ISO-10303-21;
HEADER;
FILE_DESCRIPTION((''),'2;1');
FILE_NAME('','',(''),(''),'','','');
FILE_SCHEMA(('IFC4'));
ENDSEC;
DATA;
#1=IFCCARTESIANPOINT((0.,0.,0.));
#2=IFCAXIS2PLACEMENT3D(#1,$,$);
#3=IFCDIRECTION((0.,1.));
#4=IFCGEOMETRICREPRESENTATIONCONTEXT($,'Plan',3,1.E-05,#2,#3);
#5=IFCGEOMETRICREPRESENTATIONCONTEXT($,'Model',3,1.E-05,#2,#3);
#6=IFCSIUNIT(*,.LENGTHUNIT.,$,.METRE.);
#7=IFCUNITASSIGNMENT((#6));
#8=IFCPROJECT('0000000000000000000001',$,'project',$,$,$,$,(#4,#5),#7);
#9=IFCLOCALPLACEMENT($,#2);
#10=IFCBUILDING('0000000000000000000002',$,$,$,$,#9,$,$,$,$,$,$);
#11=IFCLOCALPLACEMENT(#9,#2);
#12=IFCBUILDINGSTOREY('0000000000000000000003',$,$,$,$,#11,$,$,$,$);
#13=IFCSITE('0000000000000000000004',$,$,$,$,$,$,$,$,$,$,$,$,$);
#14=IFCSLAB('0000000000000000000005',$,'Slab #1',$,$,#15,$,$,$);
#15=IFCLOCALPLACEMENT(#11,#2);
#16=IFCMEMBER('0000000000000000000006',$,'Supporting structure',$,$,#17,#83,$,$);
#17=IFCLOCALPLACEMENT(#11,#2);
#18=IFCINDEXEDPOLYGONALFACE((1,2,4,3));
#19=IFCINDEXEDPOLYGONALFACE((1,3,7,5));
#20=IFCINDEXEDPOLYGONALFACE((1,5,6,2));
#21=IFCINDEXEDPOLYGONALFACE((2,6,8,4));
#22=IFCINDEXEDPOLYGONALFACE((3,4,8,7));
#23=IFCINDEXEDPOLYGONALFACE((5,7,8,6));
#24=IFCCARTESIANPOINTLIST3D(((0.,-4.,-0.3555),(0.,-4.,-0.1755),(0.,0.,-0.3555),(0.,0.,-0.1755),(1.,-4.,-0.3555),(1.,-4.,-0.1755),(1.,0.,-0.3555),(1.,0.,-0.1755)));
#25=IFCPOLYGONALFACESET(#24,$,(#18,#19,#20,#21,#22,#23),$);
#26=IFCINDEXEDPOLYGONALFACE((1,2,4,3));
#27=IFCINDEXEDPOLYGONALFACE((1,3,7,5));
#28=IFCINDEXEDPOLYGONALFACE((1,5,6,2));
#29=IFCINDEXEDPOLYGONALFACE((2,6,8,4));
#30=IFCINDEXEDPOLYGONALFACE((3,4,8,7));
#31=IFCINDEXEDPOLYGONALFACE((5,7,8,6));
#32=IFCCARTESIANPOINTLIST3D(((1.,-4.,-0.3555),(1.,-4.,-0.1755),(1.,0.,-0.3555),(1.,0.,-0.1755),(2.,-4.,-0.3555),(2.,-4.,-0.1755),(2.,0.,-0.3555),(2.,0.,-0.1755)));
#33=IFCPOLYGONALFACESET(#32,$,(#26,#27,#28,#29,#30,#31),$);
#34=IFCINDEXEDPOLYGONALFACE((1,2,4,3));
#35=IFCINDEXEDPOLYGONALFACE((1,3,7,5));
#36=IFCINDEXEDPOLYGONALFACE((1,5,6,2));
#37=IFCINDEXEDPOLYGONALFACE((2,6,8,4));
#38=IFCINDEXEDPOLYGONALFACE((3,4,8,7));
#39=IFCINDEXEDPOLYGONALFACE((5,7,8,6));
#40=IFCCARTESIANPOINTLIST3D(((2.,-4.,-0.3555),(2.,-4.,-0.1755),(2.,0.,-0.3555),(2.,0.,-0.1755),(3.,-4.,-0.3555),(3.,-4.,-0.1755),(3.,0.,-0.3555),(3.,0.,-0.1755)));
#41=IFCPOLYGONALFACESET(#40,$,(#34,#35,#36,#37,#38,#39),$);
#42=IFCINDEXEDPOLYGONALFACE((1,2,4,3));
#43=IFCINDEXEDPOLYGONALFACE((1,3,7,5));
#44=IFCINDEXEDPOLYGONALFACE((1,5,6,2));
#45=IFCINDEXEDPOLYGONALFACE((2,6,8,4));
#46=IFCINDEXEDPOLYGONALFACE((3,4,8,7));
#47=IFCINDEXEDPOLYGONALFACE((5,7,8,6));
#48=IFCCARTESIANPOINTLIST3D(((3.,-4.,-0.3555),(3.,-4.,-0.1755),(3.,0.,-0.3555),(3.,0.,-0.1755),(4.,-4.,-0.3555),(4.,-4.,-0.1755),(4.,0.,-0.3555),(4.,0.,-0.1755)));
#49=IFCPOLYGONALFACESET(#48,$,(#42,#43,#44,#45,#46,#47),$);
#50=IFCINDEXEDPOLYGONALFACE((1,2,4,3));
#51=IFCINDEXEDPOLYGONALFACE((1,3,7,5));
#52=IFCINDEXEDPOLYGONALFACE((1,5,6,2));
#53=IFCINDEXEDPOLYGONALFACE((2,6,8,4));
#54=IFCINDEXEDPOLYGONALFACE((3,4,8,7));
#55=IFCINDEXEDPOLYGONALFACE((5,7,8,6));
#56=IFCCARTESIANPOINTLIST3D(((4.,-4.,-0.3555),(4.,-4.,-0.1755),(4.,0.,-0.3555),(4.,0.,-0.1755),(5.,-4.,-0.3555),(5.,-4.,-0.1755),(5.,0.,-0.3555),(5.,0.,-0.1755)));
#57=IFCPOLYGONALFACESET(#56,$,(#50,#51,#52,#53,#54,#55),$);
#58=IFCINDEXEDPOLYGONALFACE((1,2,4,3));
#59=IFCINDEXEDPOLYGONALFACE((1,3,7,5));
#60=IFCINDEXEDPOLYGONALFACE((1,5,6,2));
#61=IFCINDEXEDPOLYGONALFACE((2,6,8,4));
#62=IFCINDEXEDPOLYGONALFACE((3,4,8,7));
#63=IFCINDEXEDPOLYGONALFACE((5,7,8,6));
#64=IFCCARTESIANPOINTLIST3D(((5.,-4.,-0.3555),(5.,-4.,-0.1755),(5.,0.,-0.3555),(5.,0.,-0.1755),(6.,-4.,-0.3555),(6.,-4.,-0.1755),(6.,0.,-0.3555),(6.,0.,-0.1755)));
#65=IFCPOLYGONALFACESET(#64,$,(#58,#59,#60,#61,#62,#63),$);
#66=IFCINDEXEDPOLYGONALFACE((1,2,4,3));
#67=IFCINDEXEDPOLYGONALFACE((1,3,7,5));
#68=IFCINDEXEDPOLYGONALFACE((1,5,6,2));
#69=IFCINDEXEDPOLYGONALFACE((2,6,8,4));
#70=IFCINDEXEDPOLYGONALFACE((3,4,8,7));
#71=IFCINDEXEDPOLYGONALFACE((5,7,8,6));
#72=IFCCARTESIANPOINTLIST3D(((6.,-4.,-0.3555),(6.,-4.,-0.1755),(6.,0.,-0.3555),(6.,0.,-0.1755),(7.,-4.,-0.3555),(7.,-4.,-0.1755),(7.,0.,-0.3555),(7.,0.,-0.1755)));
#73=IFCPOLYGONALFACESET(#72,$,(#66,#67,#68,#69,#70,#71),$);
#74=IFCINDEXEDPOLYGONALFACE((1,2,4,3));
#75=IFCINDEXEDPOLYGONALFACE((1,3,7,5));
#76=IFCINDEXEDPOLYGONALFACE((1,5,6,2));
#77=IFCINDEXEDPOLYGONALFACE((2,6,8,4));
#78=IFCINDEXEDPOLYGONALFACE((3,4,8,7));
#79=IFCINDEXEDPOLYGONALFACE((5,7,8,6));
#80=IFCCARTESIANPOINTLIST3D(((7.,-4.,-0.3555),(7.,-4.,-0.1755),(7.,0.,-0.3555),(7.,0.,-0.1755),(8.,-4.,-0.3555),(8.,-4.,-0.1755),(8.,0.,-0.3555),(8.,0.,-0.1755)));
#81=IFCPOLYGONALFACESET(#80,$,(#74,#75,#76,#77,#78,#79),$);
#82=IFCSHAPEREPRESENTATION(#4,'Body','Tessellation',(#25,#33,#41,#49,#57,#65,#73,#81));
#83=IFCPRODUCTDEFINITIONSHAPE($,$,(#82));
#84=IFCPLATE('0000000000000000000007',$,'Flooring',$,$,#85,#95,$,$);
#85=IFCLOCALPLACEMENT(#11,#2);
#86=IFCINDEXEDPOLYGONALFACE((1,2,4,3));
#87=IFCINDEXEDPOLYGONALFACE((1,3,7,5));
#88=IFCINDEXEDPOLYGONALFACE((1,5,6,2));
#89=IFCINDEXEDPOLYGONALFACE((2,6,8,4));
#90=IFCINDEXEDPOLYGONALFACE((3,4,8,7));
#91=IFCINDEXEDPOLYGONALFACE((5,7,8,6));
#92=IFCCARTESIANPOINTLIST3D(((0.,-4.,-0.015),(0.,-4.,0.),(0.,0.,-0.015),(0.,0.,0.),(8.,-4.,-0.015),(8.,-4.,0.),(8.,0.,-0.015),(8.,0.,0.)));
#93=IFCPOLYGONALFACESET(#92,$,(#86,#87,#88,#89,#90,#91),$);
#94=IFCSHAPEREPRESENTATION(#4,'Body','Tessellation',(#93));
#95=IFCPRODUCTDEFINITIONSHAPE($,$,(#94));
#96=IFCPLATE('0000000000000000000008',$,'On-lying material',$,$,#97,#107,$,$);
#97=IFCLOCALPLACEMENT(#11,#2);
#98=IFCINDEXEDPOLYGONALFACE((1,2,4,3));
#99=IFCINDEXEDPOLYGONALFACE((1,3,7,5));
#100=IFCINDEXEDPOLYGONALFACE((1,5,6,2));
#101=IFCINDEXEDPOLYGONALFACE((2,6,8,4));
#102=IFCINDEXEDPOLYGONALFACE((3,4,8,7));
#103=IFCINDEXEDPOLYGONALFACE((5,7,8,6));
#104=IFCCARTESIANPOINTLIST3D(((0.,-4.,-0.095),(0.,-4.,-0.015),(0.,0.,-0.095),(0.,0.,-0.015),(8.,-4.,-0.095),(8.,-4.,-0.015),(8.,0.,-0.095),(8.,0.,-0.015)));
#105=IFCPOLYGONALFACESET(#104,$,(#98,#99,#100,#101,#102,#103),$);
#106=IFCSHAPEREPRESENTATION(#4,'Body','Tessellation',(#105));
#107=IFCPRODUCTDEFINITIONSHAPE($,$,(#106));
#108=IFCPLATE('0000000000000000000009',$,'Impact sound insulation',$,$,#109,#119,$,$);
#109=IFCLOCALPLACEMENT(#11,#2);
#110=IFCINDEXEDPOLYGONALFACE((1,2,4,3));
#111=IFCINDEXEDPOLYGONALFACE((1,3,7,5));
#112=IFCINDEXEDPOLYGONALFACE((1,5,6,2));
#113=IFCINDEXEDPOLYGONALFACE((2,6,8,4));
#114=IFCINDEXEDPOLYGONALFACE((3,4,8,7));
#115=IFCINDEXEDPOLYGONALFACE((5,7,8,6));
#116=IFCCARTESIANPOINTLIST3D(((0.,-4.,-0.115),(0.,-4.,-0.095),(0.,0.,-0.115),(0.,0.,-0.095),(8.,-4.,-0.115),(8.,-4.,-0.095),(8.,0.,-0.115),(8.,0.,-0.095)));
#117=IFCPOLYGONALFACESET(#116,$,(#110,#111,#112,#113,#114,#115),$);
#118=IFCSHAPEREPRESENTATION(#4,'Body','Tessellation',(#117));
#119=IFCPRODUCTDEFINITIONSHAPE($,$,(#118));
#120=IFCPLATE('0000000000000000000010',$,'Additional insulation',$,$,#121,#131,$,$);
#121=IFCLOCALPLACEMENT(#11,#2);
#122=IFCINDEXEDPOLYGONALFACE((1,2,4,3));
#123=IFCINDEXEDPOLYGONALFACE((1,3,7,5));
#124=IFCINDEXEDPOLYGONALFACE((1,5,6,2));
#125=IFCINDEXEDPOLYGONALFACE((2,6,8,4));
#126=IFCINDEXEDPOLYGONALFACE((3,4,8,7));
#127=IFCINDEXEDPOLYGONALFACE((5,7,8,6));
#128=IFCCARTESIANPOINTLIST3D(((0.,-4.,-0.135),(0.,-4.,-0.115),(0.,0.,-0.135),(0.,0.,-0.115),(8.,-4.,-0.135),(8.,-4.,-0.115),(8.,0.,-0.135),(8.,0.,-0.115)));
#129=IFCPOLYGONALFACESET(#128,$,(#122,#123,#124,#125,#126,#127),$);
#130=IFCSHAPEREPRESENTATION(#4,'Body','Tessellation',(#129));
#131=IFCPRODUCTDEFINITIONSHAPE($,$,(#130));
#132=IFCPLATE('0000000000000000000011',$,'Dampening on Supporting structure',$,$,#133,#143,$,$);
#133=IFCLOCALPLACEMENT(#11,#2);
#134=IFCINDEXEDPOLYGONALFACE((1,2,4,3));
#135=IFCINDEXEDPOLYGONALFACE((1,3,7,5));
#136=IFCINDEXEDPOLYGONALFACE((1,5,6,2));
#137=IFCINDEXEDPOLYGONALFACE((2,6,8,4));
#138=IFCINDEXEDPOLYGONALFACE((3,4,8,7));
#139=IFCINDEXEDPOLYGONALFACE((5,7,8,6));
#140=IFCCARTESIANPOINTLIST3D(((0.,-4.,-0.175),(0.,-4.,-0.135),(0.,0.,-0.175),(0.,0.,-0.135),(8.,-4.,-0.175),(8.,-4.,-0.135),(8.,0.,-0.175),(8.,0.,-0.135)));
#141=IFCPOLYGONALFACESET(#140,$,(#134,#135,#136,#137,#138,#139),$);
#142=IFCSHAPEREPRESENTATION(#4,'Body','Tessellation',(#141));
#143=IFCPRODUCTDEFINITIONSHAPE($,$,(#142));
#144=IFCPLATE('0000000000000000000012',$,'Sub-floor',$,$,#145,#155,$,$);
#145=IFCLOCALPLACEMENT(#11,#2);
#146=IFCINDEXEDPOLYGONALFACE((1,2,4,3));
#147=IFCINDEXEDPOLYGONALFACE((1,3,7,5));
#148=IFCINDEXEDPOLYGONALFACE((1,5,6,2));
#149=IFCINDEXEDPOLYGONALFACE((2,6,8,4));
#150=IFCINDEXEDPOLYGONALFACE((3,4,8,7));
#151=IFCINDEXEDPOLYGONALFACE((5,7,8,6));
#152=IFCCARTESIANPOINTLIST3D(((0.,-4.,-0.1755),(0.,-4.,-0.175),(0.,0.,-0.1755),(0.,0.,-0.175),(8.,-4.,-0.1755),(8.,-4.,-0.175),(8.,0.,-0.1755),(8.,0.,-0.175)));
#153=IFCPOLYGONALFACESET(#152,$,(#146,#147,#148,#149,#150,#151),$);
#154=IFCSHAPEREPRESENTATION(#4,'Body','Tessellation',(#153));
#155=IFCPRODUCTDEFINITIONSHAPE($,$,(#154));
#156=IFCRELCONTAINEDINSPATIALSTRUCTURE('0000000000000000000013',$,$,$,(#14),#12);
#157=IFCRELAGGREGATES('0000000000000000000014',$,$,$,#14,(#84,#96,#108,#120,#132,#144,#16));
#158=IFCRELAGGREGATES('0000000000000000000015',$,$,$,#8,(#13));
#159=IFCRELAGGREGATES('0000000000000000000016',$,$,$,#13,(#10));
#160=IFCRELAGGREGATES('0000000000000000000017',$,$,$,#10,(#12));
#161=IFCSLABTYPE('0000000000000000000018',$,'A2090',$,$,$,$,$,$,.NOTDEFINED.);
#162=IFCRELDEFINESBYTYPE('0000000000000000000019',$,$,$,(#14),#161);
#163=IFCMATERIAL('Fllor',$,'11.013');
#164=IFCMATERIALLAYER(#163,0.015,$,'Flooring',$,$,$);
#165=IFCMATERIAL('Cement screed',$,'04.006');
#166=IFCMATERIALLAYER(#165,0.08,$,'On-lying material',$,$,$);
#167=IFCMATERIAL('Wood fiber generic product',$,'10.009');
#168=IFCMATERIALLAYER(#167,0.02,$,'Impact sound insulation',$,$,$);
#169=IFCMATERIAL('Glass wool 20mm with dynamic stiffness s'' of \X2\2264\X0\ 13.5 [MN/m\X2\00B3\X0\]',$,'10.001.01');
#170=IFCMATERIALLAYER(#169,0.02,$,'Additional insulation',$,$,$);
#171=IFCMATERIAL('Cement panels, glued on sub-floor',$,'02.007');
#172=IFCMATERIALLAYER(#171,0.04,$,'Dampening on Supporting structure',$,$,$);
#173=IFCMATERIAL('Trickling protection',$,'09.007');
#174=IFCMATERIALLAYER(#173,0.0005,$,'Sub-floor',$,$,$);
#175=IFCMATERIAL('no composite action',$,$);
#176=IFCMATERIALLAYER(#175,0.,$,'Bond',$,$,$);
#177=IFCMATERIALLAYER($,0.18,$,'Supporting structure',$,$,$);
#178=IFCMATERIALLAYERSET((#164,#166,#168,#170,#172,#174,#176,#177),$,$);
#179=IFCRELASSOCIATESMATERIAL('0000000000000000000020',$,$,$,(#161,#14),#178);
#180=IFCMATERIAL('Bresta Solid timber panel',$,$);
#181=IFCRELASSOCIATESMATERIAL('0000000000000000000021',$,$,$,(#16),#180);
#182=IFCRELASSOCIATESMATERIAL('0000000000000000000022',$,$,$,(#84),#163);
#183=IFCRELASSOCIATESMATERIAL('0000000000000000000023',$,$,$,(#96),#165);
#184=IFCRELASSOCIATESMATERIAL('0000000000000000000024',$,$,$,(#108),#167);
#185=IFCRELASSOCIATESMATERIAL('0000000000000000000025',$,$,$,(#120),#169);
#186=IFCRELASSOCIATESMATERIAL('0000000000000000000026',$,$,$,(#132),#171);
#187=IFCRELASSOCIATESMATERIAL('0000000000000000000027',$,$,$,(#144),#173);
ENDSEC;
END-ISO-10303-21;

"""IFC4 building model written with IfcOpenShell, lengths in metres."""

from ifc_helpers import new_model, si_unit, direction, frame, frame_2d, origin, origin_with_axes, place, context, project, spatial, rectangle, extrude, material, layer, layer_set, type_object, element, aggregate, save


model = new_model("IFC4")

# Units and contexts
plan_context = context("Plan", 3, precision=1e-05, world=origin(), true_north=direction((0.0, 1.0)))
model_context = context("Model", 3, precision=1e-05, world=origin(), true_north=direction((0.0, 1.0)))
ifc_project = project(units=[si_unit("LENGTHUNIT", "METRE")], contexts=[plan_context, model_context])

# Site, building, storey
site = spatial("IfcSite", under=ifc_project)
building_placement = place(None, origin())
building = spatial("IfcBuilding", under=site, at=building_placement)
storey_placement = place(building_placement, origin())
storey = spatial("IfcBuildingStorey", under=building, at=storey_placement)

# Slab, member, plates
ifc_material_1 = material(Name="Fllor", Category="11.013")
ifc_layer_1 = layer(ifc_material_1, 0.015, Name="Flooring")
ifc_material_2 = material(Name="Cement screed", Category="04.006")
ifc_layer_2 = layer(ifc_material_2, 0.08, Name="On-lying material")
ifc_material_3 = material(Name="Wood fiber generic product", Category="10.009")
ifc_layer_3 = layer(ifc_material_3, 0.02, Name="Impact sound insulation")
ifc_material_4 = material(Name="Glass wool 20mm with dynamic stiffness s' of ≤ 13.5 [MN/m³]", Category="10.001.01")
ifc_layer_4 = layer(ifc_material_4, 0.02, Name="Additional insulation")
ifc_material_5 = material(Name="Cement panels, glued on sub-floor", Category="02.007")
ifc_layer_5 = layer(ifc_material_5, 0.04, Name="Dampening on Supporting structure")
ifc_material_6 = material(Name="Trickling protection", Category="09.007")
ifc_layer_6 = layer(ifc_material_6, 0.0005, Name="Sub-floor")
ifc_material_7 = material(Name="no composite action")
ifc_layer_7 = layer(ifc_material_7, 0.0, Name="Bond")
ifc_layer_8 = layer(None, 0.18, Name="Supporting structure")
ifc_layer_set = layer_set([ifc_layer_1, ifc_layer_2, ifc_layer_3, ifc_layer_4, ifc_layer_5, ifc_layer_6, ifc_layer_7, ifc_layer_8])
slab_type = type_object("IfcSlabType", Name="A2090", PredefinedType="NOTDEFINED", material=ifc_layer_set)
slab_placement = place(None, frame((0.0, 0.0, 0.0), z_axis=(0.0, 0.0, -1.0), x_axis=(1.0, 0.0, 0.0)))
slab = element("IfcSlab", 1, at=slab_placement, inside=storey, type_object=slab_type, material=ifc_layer_set, Name="Slab #1")
ifc_material_8 = material(Name="Bresta Solid timber panel")
member_placement = place(slab_placement, origin())
member = element("IfcMember", 2, at=member_placement, material=ifc_material_8, Name="Supporting structure", context=plan_context, shape_type="SweptSolid", body=[
    extrude(rectangle(XDim=1.0, YDim=0.18, at=frame_2d((0.5, 0.09), x_axis=(1.0, 0.0))), frame((0.0, 4.0, 0.1755), z_axis=(0.0, -1.0, 0.0), x_axis=(1.0, 0.0, 0.0)), (0.0, 0.0, 1.0), 4.0),
    extrude(rectangle(XDim=1.0, YDim=0.18, at=frame_2d((0.5, 0.09), x_axis=(1.0, 0.0))), frame((1.0, 4.0, 0.1755), z_axis=(0.0, -1.0, 0.0), x_axis=(1.0, 0.0, 0.0)), (0.0, 0.0, 1.0), 4.0),
    extrude(rectangle(XDim=1.0, YDim=0.18, at=frame_2d((0.5, 0.09), x_axis=(1.0, 0.0))), frame((2.0, 4.0, 0.1755), z_axis=(0.0, -1.0, 0.0), x_axis=(1.0, 0.0, 0.0)), (0.0, 0.0, 1.0), 4.0),
    extrude(rectangle(XDim=1.0, YDim=0.18, at=frame_2d((0.5, 0.09), x_axis=(1.0, 0.0))), frame((3.0, 4.0, 0.1755), z_axis=(0.0, -1.0, 0.0), x_axis=(1.0, 0.0, 0.0)), (0.0, 0.0, 1.0), 4.0),
    extrude(rectangle(XDim=1.0, YDim=0.18, at=frame_2d((0.5, 0.09), x_axis=(1.0, 0.0))), frame((4.0, 4.0, 0.1755), z_axis=(0.0, -1.0, 0.0), x_axis=(1.0, 0.0, 0.0)), (0.0, 0.0, 1.0), 4.0),
    extrude(rectangle(XDim=1.0, YDim=0.18, at=frame_2d((0.5, 0.09), x_axis=(1.0, 0.0))), frame((5.0, 4.0, 0.1755), z_axis=(0.0, -1.0, 0.0), x_axis=(1.0, 0.0, 0.0)), (0.0, 0.0, 1.0), 4.0),
    extrude(rectangle(XDim=1.0, YDim=0.18, at=frame_2d((0.5, 0.09), x_axis=(1.0, 0.0))), frame((6.0, 4.0, 0.1755), z_axis=(0.0, -1.0, 0.0), x_axis=(1.0, 0.0, 0.0)), (0.0, 0.0, 1.0), 4.0),
    extrude(rectangle(XDim=1.0, YDim=0.18, at=frame_2d((0.5, 0.09), x_axis=(1.0, 0.0))), frame((7.0, 4.0, 0.1755), z_axis=(0.0, -1.0, 0.0), x_axis=(1.0, 0.0, 0.0)), (0.0, 0.0, 1.0), 4.0),
])
plate_1_placement = place(slab_placement, origin())
plate_1 = element("IfcPlate", 3, at=plate_1_placement, material=ifc_material_1, Name="Flooring", context=plan_context, shape_type="SweptSolid", body=[
    extrude(rectangle(XDim=8.0, YDim=4.0, at=frame_2d((4.0, 2.0), x_axis=(1.0, 0.0))), origin_with_axes(), (0.0, 0.0, 1.0), 0.015),
])
plate_2_placement = place(slab_placement, origin())
plate_2 = element("IfcPlate", 4, at=plate_2_placement, material=ifc_material_2, Name="On-lying material", context=plan_context, shape_type="SweptSolid", body=[
    extrude(rectangle(XDim=8.0, YDim=4.0, at=frame_2d((4.0, 2.0), x_axis=(1.0, 0.0))), frame((0.0, 0.0, 0.015), z_axis=(0.0, 0.0, 1.0), x_axis=(1.0, 0.0, 0.0)), (0.0, 0.0, 1.0), 0.08),
])
plate_3_placement = place(slab_placement, origin())
plate_3 = element("IfcPlate", 5, at=plate_3_placement, material=ifc_material_3, Name="Impact sound insulation", context=plan_context, shape_type="SweptSolid", body=[
    extrude(rectangle(XDim=8.0, YDim=4.0, at=frame_2d((4.0, 2.0), x_axis=(1.0, 0.0))), frame((0.0, 0.0, 0.095), z_axis=(0.0, 0.0, 1.0), x_axis=(1.0, 0.0, 0.0)), (0.0, 0.0, 1.0), 0.02),
])
plate_4_placement = place(slab_placement, origin())
plate_4 = element("IfcPlate", 6, at=plate_4_placement, material=ifc_material_4, Name="Additional insulation", context=plan_context, shape_type="SweptSolid", body=[
    extrude(rectangle(XDim=8.0, YDim=4.0, at=frame_2d((4.0, 2.0), x_axis=(1.0, 0.0))), frame((0.0, 0.0, 0.115), z_axis=(0.0, 0.0, 1.0), x_axis=(1.0, 0.0, 0.0)), (0.0, 0.0, 1.0), 0.02),
])
plate_5_placement = place(slab_placement, origin())
plate_5 = element("IfcPlate", 7, at=plate_5_placement, material=ifc_material_5, Name="Dampening on Supporting structure", context=plan_context, shape_type="SweptSolid", body=[
    extrude(rectangle(XDim=8.0, YDim=4.0, at=frame_2d((4.0, 2.0), x_axis=(1.0, 0.0))), frame((0.0, 0.0, 0.135), z_axis=(0.0, 0.0, 1.0), x_axis=(1.0, 0.0, 0.0)), (0.0, 0.0, 1.0), 0.04),
])
plate_6_placement = place(slab_placement, origin())
plate_6 = element("IfcPlate", 8, at=plate_6_placement, material=ifc_material_6, Name="Sub-floor", context=plan_context, shape_type="SweptSolid", body=[
    extrude(rectangle(XDim=8.0, YDim=4.0, at=frame_2d((4.0, 2.0), x_axis=(1.0, 0.0))), frame((0.0, 0.0, 0.175), z_axis=(0.0, 0.0, 1.0), x_axis=(1.0, 0.0, 0.0)), (0.0, 0.0, 1.0), 0.0005),
])
aggregate(slab, [plate_1, plate_2, plate_3, plate_4, plate_5, plate_6, member])

save(model, "model.ifc")
